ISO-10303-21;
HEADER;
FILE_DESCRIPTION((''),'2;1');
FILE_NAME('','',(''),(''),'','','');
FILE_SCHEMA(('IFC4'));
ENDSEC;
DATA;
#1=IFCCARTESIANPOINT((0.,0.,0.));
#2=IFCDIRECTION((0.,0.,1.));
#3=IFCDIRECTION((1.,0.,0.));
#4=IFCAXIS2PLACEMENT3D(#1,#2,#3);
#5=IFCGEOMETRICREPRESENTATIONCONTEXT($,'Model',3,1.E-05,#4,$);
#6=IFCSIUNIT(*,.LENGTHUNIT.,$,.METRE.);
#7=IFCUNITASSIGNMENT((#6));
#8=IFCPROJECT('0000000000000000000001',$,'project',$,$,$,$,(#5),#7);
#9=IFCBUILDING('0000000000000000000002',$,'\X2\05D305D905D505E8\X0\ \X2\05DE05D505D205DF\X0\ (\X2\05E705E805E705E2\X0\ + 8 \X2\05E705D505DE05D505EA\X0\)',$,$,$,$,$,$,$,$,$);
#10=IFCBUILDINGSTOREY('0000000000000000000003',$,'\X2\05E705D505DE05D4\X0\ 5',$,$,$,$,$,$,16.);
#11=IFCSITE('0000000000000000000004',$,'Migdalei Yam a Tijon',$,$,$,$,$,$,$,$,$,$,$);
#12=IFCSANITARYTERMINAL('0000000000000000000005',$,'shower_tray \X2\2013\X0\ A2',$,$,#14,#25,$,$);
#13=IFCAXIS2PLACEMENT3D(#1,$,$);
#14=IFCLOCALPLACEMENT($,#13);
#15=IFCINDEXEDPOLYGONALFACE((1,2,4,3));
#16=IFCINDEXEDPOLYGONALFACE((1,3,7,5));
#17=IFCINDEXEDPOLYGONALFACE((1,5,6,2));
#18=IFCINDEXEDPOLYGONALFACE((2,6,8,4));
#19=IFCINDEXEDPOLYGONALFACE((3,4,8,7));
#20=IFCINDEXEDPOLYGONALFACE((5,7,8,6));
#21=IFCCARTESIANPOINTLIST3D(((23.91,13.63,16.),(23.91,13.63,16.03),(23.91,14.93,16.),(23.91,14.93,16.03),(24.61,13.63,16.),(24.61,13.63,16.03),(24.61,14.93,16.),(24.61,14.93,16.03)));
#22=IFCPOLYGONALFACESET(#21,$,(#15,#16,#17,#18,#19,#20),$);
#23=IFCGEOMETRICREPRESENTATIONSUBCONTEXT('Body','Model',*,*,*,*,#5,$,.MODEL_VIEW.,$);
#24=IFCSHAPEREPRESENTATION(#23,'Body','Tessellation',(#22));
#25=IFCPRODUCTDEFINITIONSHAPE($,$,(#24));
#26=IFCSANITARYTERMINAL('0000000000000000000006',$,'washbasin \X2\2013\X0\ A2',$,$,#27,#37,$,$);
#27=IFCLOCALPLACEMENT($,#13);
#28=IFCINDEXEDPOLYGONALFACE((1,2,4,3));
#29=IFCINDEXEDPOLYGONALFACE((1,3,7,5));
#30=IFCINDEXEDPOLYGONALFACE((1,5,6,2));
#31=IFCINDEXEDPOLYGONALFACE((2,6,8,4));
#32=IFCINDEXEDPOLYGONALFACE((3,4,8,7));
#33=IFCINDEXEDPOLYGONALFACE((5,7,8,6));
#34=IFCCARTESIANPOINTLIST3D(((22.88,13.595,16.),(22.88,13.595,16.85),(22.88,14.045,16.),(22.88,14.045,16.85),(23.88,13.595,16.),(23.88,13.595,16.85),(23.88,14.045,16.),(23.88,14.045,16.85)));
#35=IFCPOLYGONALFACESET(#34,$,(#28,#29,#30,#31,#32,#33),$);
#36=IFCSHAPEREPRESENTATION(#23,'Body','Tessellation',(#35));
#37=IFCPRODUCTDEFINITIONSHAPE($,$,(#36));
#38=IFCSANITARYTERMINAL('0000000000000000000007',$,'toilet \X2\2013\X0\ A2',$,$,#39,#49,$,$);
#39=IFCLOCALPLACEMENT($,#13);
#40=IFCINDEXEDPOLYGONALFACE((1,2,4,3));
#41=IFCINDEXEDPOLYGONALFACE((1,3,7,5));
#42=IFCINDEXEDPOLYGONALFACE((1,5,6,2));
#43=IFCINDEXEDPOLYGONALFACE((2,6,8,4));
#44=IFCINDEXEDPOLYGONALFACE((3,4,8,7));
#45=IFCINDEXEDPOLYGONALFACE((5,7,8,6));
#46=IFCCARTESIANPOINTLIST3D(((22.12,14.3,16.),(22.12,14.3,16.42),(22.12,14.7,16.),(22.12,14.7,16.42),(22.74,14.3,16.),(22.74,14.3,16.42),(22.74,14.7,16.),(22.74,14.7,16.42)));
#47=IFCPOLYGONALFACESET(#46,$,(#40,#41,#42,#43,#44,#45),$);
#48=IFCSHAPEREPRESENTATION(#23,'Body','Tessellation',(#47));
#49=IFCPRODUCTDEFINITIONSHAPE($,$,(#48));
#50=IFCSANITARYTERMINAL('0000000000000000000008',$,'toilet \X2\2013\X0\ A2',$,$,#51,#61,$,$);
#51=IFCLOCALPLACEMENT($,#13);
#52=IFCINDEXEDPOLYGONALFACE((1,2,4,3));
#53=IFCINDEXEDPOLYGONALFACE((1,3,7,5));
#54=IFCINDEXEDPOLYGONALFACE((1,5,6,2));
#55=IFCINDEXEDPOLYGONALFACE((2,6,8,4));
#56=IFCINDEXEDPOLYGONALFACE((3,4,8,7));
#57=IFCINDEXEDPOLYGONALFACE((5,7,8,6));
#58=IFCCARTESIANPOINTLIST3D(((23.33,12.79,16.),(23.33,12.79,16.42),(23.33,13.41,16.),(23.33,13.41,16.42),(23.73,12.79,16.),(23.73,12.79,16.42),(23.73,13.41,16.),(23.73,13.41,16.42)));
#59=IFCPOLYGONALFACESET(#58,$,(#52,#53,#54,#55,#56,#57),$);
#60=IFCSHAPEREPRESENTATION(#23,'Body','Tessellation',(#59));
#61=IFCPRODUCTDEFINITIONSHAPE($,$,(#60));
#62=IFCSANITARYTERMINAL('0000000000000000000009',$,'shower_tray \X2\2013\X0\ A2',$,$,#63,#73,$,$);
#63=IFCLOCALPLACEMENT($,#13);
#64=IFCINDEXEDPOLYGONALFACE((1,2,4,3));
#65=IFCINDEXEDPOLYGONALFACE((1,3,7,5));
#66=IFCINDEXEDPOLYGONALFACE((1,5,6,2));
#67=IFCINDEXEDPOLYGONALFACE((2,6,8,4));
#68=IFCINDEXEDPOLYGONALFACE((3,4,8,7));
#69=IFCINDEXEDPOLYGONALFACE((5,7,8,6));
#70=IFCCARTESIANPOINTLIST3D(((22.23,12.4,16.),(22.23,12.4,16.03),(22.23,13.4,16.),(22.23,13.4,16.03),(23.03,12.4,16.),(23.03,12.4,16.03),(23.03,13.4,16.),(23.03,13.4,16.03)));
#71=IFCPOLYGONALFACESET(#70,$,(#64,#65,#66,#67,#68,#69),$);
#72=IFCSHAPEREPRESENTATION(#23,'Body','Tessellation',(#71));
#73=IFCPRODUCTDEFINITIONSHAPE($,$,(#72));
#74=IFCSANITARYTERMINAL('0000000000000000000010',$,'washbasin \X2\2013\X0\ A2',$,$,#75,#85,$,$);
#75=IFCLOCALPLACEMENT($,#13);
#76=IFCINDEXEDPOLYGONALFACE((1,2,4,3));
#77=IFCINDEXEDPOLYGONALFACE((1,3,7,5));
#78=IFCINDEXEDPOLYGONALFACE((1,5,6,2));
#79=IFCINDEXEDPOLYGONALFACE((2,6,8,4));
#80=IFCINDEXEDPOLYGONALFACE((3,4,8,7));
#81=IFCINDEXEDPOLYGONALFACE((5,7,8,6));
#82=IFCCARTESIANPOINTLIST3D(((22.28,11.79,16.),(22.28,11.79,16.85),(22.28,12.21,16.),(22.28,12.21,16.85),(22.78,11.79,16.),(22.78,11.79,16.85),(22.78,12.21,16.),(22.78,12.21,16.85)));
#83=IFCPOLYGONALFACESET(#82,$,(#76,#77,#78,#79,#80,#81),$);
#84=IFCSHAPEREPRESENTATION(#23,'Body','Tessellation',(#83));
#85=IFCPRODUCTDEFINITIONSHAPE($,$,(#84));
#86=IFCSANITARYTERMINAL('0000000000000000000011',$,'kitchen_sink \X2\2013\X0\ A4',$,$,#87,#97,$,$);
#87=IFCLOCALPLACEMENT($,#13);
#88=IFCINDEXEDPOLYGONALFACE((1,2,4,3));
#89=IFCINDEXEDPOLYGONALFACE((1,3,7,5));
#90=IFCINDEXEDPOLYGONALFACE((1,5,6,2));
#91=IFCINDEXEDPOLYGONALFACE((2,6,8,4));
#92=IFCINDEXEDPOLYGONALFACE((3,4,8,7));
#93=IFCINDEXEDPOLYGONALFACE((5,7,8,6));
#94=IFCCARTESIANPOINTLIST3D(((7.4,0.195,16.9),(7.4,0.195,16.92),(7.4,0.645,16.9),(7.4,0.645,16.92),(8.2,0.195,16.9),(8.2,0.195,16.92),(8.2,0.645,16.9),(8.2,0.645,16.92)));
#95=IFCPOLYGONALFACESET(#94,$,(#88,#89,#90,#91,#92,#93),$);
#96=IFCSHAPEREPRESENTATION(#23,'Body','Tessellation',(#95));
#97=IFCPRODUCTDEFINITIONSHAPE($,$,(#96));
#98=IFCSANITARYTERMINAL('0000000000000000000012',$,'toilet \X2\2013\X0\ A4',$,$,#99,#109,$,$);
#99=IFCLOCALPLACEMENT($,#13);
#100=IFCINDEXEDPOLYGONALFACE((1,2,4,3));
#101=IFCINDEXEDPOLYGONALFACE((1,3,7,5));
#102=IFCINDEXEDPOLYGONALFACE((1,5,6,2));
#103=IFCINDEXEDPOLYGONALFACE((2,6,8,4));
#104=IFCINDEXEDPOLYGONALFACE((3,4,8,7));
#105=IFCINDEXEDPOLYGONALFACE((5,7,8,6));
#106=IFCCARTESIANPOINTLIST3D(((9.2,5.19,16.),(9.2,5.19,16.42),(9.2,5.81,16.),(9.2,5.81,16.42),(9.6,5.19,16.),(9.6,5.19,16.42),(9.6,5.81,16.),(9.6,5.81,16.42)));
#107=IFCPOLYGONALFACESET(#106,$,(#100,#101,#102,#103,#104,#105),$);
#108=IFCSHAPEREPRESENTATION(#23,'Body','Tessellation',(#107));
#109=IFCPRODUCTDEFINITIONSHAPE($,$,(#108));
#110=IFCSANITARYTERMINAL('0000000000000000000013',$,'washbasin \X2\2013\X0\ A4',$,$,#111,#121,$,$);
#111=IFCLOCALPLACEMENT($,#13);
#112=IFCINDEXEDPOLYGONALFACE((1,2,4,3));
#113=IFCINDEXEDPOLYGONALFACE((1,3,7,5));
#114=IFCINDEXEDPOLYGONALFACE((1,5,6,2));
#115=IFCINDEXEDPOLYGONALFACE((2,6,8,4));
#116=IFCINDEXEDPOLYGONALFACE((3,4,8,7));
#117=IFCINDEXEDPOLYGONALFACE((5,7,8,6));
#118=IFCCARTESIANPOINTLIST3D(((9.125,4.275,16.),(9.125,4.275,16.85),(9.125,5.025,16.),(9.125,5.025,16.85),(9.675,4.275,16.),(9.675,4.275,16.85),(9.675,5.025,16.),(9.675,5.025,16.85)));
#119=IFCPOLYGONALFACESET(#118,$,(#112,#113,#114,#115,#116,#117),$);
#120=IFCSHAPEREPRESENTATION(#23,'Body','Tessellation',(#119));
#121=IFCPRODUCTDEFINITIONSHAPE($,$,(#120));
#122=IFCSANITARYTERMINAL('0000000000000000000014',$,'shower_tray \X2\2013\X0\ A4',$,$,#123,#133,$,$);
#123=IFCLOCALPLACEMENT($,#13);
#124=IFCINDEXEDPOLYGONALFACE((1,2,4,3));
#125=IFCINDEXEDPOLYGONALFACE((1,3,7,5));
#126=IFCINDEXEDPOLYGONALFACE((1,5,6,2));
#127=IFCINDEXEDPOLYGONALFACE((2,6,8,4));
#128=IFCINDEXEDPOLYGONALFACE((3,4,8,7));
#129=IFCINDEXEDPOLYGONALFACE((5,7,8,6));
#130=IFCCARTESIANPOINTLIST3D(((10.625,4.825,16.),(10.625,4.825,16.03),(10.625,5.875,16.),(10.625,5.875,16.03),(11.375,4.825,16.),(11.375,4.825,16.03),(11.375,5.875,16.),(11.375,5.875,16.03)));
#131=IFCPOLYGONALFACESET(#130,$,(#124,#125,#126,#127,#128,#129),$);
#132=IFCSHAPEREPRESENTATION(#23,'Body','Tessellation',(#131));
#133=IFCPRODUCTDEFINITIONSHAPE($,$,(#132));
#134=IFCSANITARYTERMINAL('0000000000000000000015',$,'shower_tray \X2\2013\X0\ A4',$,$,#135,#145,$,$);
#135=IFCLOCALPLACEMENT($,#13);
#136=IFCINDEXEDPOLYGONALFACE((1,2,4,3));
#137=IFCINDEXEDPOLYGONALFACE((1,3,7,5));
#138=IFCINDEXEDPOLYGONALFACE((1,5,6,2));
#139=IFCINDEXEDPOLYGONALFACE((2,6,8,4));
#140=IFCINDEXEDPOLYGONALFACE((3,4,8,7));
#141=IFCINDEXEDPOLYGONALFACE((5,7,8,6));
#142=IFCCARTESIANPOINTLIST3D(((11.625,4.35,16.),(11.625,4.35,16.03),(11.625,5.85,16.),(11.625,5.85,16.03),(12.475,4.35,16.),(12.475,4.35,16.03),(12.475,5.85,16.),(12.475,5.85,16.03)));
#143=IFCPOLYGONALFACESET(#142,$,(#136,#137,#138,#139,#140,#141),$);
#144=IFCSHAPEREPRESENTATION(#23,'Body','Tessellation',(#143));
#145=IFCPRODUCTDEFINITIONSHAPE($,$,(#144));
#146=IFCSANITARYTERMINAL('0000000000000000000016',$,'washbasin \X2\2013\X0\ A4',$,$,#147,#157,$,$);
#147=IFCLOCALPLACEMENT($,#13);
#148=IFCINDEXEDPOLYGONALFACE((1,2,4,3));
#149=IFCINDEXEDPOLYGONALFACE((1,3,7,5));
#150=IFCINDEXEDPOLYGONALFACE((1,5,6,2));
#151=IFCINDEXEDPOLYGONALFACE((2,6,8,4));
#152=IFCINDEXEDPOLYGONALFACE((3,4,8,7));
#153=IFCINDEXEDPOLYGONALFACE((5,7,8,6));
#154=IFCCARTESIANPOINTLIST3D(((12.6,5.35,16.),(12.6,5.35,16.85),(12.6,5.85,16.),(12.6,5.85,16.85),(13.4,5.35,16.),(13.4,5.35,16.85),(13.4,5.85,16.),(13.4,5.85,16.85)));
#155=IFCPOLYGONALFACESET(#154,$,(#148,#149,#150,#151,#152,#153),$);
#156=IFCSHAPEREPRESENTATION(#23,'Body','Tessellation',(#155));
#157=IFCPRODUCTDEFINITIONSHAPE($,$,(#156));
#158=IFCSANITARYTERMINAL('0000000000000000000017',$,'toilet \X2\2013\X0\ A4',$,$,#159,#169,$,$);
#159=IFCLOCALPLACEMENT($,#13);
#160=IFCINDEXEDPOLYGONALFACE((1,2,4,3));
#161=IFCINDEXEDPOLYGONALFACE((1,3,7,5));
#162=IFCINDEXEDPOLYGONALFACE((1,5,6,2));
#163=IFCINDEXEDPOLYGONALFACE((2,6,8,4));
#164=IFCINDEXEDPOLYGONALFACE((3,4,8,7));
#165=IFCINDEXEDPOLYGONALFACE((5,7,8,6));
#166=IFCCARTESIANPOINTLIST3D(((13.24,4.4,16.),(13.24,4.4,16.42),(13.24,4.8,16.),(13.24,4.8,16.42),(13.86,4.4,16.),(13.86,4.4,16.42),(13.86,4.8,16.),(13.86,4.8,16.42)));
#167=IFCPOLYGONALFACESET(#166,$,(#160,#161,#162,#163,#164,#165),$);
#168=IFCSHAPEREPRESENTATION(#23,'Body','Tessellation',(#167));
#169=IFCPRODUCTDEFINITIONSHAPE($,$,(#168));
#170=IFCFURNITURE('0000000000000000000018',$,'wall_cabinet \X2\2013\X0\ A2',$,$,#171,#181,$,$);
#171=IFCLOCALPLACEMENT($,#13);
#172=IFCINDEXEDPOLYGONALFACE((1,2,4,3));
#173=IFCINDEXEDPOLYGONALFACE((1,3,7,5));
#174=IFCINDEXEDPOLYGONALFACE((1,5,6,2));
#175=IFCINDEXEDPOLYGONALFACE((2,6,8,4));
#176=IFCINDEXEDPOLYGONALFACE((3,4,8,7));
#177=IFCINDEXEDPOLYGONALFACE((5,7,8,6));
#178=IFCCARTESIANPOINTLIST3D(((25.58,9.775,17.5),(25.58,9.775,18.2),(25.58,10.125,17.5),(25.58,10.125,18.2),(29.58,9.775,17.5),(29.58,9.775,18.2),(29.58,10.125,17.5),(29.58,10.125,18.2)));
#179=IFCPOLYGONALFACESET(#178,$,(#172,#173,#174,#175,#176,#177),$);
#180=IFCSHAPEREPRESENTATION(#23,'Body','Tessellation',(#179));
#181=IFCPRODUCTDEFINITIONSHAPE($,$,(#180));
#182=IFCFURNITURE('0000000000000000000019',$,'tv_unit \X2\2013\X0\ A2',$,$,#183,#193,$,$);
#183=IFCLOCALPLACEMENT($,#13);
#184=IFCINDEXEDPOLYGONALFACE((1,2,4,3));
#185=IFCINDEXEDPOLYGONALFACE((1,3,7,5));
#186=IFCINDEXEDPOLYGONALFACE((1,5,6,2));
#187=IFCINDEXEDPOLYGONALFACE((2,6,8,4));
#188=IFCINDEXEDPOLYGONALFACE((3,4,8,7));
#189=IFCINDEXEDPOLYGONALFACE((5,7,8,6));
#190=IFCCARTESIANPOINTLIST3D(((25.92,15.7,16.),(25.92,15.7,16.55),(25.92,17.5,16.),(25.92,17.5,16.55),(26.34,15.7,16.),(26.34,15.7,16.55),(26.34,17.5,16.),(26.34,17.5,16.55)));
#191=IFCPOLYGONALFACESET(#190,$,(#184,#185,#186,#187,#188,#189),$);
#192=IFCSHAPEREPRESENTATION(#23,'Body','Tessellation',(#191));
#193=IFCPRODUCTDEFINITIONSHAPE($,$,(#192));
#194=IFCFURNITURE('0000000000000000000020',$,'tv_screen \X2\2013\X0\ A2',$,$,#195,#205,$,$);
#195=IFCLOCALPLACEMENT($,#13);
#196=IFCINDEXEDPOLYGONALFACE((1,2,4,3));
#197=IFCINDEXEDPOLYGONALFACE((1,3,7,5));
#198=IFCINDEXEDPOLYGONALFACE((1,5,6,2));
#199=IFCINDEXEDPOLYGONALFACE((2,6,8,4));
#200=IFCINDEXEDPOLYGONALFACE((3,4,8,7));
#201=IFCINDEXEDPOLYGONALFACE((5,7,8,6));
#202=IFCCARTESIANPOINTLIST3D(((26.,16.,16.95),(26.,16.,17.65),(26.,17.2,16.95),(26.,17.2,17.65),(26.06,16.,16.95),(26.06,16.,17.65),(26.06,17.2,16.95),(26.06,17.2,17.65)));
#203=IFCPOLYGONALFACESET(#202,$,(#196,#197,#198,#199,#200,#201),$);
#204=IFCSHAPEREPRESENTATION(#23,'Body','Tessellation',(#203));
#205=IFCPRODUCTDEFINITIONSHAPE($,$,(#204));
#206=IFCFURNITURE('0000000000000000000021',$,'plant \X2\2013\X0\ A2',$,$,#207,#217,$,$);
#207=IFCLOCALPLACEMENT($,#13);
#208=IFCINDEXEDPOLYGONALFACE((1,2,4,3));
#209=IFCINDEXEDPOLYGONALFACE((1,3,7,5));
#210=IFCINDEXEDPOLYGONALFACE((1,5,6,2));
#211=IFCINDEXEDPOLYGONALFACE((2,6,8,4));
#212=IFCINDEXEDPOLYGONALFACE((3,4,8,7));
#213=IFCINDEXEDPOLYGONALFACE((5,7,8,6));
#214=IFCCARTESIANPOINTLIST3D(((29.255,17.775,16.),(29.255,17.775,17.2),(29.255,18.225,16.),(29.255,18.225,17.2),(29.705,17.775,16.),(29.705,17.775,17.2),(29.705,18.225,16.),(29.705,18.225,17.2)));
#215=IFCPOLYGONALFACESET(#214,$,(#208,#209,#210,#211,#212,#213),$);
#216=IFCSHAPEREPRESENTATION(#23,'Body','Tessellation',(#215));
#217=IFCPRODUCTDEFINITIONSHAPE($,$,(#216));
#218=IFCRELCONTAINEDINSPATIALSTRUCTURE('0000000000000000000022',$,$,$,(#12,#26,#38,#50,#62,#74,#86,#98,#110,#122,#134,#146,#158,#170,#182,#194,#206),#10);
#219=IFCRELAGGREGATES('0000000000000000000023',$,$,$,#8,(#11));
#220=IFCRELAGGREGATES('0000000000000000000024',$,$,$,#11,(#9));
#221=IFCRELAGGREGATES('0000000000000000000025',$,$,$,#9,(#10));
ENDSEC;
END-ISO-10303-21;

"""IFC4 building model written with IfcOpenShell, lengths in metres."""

from ifc_helpers import new_model, si_unit, frame, origin_with_axes, context, subcontext, project, spatial, line, indexed_curve, outline, extrude, element, save


model = new_model("IFC4")

# Units and contexts
model_context = context("Model", 3, precision=1e-05, world=origin_with_axes())
body_context = subcontext(model_context, "Body", "Model", "MODEL_VIEW")
ifc_project = project(units=[si_unit("LENGTHUNIT", "METRE")], contexts=[model_context])

# Site, building, storey
site = spatial("IfcSite", under=ifc_project, Name="Migdalei Yam a Tijon")
building = spatial("IfcBuilding", under=site, Name="דיור מוגן (קרקע + 8 קומות)")
storey = spatial("IfcBuildingStorey", under=building, Name="קומה 5", Elevation=16.0)

# Sanitary terminals
element("IfcSanitaryTerminal", 1, inside=storey, Name="shower_tray – A2", context=body_context, shape_type="SweptSolid", body=[
    extrude(outline(indexed_curve([(0.0, 0.0), (0.7, 0.0), (0.7, 1.3), (0.0, 1.3)], segments=[line(1, 2, 3, 4, 1)])), frame((23.91, 13.63, 16.0), z_axis=(0.0, 0.0, 1.0), x_axis=(1.0, 0.0, 0.0)), (0.0, 0.0, 1.0), 0.03),
])
element("IfcSanitaryTerminal", 2, inside=storey, Name="washbasin – A2", context=body_context, shape_type="SweptSolid", body=[
    extrude(outline(indexed_curve([(0.0, 0.0), (1.0, 0.0), (1.0, 0.45), (0.0, 0.45)], segments=[line(1, 2, 3, 4, 1)])), frame((22.88, 13.595, 16.0), z_axis=(0.0, 0.0, 1.0), x_axis=(1.0, 0.0, 0.0)), (0.0, 0.0, 1.0), 0.85),
])
element("IfcSanitaryTerminal", 3, inside=storey, Name="toilet – A2", context=body_context, shape_type="SweptSolid", body=[
    extrude(outline(indexed_curve([(0.0, 0.0), (0.62, 0.0), (0.62, 0.4), (0.0, 0.4)], segments=[line(1, 2, 3, 4, 1)])), frame((22.12, 14.3, 16.0), z_axis=(0.0, 0.0, 1.0), x_axis=(1.0, 0.0, 0.0)), (0.0, 0.0, 1.0), 0.42),
])
element("IfcSanitaryTerminal", 4, inside=storey, Name="toilet – A2", context=body_context, shape_type="SweptSolid", body=[
    extrude(outline(indexed_curve([(0.0, 0.0), (0.4, 0.0), (0.4, 0.62), (0.0, 0.62)], segments=[line(1, 2, 3, 4, 1)])), frame((23.33, 12.79, 16.0), z_axis=(0.0, 0.0, 1.0), x_axis=(1.0, 0.0, 0.0)), (0.0, 0.0, 1.0), 0.42),
])
element("IfcSanitaryTerminal", 5, inside=storey, Name="shower_tray – A2", context=body_context, shape_type="SweptSolid", body=[
    extrude(outline(indexed_curve([(0.0, 0.0), (0.8, 0.0), (0.8, 1.0), (0.0, 1.0)], segments=[line(1, 2, 3, 4, 1)])), frame((22.23, 12.4, 16.0), z_axis=(0.0, 0.0, 1.0), x_axis=(1.0, 0.0, 0.0)), (0.0, 0.0, 1.0), 0.03),
])
element("IfcSanitaryTerminal", 6, inside=storey, Name="washbasin – A2", context=body_context, shape_type="SweptSolid", body=[
    extrude(outline(indexed_curve([(0.0, 0.0), (0.5, 0.0), (0.5, 0.42), (0.0, 0.42)], segments=[line(1, 2, 3, 4, 1)])), frame((22.28, 11.79, 16.0), z_axis=(0.0, 0.0, 1.0), x_axis=(1.0, 0.0, 0.0)), (0.0, 0.0, 1.0), 0.85),
])
element("IfcSanitaryTerminal", 7, inside=storey, Name="kitchen_sink – A4", context=body_context, shape_type="SweptSolid", body=[
    extrude(outline(indexed_curve([(0.0, 0.0), (0.8, 0.0), (0.8, 0.45), (0.0, 0.45)], segments=[line(1, 2, 3, 4, 1)])), frame((7.4, 0.195, 16.9), z_axis=(0.0, 0.0, 1.0), x_axis=(1.0, 0.0, 0.0)), (0.0, 0.0, 1.0), 0.02),
])
element("IfcSanitaryTerminal", 8, inside=storey, Name="toilet – A4", context=body_context, shape_type="SweptSolid", body=[
    extrude(outline(indexed_curve([(0.0, 0.0), (0.4, 0.0), (0.4, 0.62), (0.0, 0.62)], segments=[line(1, 2, 3, 4, 1)])), frame((9.2, 5.19, 16.0), z_axis=(0.0, 0.0, 1.0), x_axis=(1.0, 0.0, 0.0)), (0.0, 0.0, 1.0), 0.42),
])
element("IfcSanitaryTerminal", 9, inside=storey, Name="washbasin – A4", context=body_context, shape_type="SweptSolid", body=[
    extrude(outline(indexed_curve([(0.0, 0.0), (0.55, 0.0), (0.55, 0.75), (0.0, 0.75)], segments=[line(1, 2, 3, 4, 1)])), frame((9.125, 4.275, 16.0), z_axis=(0.0, 0.0, 1.0), x_axis=(1.0, 0.0, 0.0)), (0.0, 0.0, 1.0), 0.85),
])
element("IfcSanitaryTerminal", 10, inside=storey, Name="shower_tray – A4", context=body_context, shape_type="SweptSolid", body=[
    extrude(outline(indexed_curve([(0.0, 0.0), (0.75, 0.0), (0.75, 1.05), (0.0, 1.05)], segments=[line(1, 2, 3, 4, 1)])), frame((10.625, 4.825, 16.0), z_axis=(0.0, 0.0, 1.0), x_axis=(1.0, 0.0, 0.0)), (0.0, 0.0, 1.0), 0.03),
])
element("IfcSanitaryTerminal", 11, inside=storey, Name="shower_tray – A4", context=body_context, shape_type="SweptSolid", body=[
    extrude(outline(indexed_curve([(0.0, 0.0), (0.85, 0.0), (0.85, 1.5), (0.0, 1.5)], segments=[line(1, 2, 3, 4, 1)])), frame((11.625, 4.35, 16.0), z_axis=(0.0, 0.0, 1.0), x_axis=(1.0, 0.0, 0.0)), (0.0, 0.0, 1.0), 0.03),
])
element("IfcSanitaryTerminal", 12, inside=storey, Name="washbasin – A4", context=body_context, shape_type="SweptSolid", body=[
    extrude(outline(indexed_curve([(0.0, 0.0), (0.8, 0.0), (0.8, 0.5), (0.0, 0.5)], segments=[line(1, 2, 3, 4, 1)])), frame((12.6, 5.35, 16.0), z_axis=(0.0, 0.0, 1.0), x_axis=(1.0, 0.0, 0.0)), (0.0, 0.0, 1.0), 0.85),
])
element("IfcSanitaryTerminal", 13, inside=storey, Name="toilet – A4", context=body_context, shape_type="SweptSolid", body=[
    extrude(outline(indexed_curve([(0.0, 0.0), (0.62, 0.0), (0.62, 0.4), (0.0, 0.4)], segments=[line(1, 2, 3, 4, 1)])), frame((13.24, 4.4, 16.0), z_axis=(0.0, 0.0, 1.0), x_axis=(1.0, 0.0, 0.0)), (0.0, 0.0, 1.0), 0.42),
])

# Furniture
element("IfcFurniture", 14, inside=storey, Name="wall_cabinet – A2", context=body_context, shape_type="SweptSolid", body=[
    extrude(outline(indexed_curve([(0.0, 0.0), (4.0, 0.0), (4.0, 0.35), (0.0, 0.35)], segments=[line(1, 2, 3, 4, 1)])), frame((25.58, 9.775, 17.5), z_axis=(0.0, 0.0, 1.0), x_axis=(1.0, 0.0, 0.0)), (0.0, 0.0, 1.0), 0.7),
])
element("IfcFurniture", 15, inside=storey, Name="tv_unit – A2", context=body_context, shape_type="SweptSolid", body=[
    extrude(outline(indexed_curve([(0.0, 0.0), (0.42, 0.0), (0.42, 1.8), (0.0, 1.8)], segments=[line(1, 2, 3, 4, 1)])), frame((25.92, 15.7, 16.0), z_axis=(0.0, 0.0, 1.0), x_axis=(1.0, 0.0, 0.0)), (0.0, 0.0, 1.0), 0.55),
])
element("IfcFurniture", 16, inside=storey, Name="tv_screen – A2", context=body_context, shape_type="SweptSolid", body=[
    extrude(outline(indexed_curve([(0.0, 0.0), (0.06, 0.0), (0.06, 1.2), (0.0, 1.2)], segments=[line(1, 2, 3, 4, 1)])), frame((26.0, 16.0, 16.95), z_axis=(0.0, 0.0, 1.0), x_axis=(1.0, 0.0, 0.0)), (0.0, 0.0, 1.0), 0.7),
])
element("IfcFurniture", 17, inside=storey, Name="plant – A2", context=body_context, shape_type="SweptSolid", body=[
    extrude(outline(indexed_curve([(0.0, 0.0), (0.45, 0.0), (0.45, 0.45), (0.0, 0.45)], segments=[line(1, 2, 3, 4, 1)])), frame((29.255, 17.775, 16.0), z_axis=(0.0, 0.0, 1.0), x_axis=(1.0, 0.0, 0.0)), (0.0, 0.0, 1.0), 1.2),
])

save(model, "model.ifc")
